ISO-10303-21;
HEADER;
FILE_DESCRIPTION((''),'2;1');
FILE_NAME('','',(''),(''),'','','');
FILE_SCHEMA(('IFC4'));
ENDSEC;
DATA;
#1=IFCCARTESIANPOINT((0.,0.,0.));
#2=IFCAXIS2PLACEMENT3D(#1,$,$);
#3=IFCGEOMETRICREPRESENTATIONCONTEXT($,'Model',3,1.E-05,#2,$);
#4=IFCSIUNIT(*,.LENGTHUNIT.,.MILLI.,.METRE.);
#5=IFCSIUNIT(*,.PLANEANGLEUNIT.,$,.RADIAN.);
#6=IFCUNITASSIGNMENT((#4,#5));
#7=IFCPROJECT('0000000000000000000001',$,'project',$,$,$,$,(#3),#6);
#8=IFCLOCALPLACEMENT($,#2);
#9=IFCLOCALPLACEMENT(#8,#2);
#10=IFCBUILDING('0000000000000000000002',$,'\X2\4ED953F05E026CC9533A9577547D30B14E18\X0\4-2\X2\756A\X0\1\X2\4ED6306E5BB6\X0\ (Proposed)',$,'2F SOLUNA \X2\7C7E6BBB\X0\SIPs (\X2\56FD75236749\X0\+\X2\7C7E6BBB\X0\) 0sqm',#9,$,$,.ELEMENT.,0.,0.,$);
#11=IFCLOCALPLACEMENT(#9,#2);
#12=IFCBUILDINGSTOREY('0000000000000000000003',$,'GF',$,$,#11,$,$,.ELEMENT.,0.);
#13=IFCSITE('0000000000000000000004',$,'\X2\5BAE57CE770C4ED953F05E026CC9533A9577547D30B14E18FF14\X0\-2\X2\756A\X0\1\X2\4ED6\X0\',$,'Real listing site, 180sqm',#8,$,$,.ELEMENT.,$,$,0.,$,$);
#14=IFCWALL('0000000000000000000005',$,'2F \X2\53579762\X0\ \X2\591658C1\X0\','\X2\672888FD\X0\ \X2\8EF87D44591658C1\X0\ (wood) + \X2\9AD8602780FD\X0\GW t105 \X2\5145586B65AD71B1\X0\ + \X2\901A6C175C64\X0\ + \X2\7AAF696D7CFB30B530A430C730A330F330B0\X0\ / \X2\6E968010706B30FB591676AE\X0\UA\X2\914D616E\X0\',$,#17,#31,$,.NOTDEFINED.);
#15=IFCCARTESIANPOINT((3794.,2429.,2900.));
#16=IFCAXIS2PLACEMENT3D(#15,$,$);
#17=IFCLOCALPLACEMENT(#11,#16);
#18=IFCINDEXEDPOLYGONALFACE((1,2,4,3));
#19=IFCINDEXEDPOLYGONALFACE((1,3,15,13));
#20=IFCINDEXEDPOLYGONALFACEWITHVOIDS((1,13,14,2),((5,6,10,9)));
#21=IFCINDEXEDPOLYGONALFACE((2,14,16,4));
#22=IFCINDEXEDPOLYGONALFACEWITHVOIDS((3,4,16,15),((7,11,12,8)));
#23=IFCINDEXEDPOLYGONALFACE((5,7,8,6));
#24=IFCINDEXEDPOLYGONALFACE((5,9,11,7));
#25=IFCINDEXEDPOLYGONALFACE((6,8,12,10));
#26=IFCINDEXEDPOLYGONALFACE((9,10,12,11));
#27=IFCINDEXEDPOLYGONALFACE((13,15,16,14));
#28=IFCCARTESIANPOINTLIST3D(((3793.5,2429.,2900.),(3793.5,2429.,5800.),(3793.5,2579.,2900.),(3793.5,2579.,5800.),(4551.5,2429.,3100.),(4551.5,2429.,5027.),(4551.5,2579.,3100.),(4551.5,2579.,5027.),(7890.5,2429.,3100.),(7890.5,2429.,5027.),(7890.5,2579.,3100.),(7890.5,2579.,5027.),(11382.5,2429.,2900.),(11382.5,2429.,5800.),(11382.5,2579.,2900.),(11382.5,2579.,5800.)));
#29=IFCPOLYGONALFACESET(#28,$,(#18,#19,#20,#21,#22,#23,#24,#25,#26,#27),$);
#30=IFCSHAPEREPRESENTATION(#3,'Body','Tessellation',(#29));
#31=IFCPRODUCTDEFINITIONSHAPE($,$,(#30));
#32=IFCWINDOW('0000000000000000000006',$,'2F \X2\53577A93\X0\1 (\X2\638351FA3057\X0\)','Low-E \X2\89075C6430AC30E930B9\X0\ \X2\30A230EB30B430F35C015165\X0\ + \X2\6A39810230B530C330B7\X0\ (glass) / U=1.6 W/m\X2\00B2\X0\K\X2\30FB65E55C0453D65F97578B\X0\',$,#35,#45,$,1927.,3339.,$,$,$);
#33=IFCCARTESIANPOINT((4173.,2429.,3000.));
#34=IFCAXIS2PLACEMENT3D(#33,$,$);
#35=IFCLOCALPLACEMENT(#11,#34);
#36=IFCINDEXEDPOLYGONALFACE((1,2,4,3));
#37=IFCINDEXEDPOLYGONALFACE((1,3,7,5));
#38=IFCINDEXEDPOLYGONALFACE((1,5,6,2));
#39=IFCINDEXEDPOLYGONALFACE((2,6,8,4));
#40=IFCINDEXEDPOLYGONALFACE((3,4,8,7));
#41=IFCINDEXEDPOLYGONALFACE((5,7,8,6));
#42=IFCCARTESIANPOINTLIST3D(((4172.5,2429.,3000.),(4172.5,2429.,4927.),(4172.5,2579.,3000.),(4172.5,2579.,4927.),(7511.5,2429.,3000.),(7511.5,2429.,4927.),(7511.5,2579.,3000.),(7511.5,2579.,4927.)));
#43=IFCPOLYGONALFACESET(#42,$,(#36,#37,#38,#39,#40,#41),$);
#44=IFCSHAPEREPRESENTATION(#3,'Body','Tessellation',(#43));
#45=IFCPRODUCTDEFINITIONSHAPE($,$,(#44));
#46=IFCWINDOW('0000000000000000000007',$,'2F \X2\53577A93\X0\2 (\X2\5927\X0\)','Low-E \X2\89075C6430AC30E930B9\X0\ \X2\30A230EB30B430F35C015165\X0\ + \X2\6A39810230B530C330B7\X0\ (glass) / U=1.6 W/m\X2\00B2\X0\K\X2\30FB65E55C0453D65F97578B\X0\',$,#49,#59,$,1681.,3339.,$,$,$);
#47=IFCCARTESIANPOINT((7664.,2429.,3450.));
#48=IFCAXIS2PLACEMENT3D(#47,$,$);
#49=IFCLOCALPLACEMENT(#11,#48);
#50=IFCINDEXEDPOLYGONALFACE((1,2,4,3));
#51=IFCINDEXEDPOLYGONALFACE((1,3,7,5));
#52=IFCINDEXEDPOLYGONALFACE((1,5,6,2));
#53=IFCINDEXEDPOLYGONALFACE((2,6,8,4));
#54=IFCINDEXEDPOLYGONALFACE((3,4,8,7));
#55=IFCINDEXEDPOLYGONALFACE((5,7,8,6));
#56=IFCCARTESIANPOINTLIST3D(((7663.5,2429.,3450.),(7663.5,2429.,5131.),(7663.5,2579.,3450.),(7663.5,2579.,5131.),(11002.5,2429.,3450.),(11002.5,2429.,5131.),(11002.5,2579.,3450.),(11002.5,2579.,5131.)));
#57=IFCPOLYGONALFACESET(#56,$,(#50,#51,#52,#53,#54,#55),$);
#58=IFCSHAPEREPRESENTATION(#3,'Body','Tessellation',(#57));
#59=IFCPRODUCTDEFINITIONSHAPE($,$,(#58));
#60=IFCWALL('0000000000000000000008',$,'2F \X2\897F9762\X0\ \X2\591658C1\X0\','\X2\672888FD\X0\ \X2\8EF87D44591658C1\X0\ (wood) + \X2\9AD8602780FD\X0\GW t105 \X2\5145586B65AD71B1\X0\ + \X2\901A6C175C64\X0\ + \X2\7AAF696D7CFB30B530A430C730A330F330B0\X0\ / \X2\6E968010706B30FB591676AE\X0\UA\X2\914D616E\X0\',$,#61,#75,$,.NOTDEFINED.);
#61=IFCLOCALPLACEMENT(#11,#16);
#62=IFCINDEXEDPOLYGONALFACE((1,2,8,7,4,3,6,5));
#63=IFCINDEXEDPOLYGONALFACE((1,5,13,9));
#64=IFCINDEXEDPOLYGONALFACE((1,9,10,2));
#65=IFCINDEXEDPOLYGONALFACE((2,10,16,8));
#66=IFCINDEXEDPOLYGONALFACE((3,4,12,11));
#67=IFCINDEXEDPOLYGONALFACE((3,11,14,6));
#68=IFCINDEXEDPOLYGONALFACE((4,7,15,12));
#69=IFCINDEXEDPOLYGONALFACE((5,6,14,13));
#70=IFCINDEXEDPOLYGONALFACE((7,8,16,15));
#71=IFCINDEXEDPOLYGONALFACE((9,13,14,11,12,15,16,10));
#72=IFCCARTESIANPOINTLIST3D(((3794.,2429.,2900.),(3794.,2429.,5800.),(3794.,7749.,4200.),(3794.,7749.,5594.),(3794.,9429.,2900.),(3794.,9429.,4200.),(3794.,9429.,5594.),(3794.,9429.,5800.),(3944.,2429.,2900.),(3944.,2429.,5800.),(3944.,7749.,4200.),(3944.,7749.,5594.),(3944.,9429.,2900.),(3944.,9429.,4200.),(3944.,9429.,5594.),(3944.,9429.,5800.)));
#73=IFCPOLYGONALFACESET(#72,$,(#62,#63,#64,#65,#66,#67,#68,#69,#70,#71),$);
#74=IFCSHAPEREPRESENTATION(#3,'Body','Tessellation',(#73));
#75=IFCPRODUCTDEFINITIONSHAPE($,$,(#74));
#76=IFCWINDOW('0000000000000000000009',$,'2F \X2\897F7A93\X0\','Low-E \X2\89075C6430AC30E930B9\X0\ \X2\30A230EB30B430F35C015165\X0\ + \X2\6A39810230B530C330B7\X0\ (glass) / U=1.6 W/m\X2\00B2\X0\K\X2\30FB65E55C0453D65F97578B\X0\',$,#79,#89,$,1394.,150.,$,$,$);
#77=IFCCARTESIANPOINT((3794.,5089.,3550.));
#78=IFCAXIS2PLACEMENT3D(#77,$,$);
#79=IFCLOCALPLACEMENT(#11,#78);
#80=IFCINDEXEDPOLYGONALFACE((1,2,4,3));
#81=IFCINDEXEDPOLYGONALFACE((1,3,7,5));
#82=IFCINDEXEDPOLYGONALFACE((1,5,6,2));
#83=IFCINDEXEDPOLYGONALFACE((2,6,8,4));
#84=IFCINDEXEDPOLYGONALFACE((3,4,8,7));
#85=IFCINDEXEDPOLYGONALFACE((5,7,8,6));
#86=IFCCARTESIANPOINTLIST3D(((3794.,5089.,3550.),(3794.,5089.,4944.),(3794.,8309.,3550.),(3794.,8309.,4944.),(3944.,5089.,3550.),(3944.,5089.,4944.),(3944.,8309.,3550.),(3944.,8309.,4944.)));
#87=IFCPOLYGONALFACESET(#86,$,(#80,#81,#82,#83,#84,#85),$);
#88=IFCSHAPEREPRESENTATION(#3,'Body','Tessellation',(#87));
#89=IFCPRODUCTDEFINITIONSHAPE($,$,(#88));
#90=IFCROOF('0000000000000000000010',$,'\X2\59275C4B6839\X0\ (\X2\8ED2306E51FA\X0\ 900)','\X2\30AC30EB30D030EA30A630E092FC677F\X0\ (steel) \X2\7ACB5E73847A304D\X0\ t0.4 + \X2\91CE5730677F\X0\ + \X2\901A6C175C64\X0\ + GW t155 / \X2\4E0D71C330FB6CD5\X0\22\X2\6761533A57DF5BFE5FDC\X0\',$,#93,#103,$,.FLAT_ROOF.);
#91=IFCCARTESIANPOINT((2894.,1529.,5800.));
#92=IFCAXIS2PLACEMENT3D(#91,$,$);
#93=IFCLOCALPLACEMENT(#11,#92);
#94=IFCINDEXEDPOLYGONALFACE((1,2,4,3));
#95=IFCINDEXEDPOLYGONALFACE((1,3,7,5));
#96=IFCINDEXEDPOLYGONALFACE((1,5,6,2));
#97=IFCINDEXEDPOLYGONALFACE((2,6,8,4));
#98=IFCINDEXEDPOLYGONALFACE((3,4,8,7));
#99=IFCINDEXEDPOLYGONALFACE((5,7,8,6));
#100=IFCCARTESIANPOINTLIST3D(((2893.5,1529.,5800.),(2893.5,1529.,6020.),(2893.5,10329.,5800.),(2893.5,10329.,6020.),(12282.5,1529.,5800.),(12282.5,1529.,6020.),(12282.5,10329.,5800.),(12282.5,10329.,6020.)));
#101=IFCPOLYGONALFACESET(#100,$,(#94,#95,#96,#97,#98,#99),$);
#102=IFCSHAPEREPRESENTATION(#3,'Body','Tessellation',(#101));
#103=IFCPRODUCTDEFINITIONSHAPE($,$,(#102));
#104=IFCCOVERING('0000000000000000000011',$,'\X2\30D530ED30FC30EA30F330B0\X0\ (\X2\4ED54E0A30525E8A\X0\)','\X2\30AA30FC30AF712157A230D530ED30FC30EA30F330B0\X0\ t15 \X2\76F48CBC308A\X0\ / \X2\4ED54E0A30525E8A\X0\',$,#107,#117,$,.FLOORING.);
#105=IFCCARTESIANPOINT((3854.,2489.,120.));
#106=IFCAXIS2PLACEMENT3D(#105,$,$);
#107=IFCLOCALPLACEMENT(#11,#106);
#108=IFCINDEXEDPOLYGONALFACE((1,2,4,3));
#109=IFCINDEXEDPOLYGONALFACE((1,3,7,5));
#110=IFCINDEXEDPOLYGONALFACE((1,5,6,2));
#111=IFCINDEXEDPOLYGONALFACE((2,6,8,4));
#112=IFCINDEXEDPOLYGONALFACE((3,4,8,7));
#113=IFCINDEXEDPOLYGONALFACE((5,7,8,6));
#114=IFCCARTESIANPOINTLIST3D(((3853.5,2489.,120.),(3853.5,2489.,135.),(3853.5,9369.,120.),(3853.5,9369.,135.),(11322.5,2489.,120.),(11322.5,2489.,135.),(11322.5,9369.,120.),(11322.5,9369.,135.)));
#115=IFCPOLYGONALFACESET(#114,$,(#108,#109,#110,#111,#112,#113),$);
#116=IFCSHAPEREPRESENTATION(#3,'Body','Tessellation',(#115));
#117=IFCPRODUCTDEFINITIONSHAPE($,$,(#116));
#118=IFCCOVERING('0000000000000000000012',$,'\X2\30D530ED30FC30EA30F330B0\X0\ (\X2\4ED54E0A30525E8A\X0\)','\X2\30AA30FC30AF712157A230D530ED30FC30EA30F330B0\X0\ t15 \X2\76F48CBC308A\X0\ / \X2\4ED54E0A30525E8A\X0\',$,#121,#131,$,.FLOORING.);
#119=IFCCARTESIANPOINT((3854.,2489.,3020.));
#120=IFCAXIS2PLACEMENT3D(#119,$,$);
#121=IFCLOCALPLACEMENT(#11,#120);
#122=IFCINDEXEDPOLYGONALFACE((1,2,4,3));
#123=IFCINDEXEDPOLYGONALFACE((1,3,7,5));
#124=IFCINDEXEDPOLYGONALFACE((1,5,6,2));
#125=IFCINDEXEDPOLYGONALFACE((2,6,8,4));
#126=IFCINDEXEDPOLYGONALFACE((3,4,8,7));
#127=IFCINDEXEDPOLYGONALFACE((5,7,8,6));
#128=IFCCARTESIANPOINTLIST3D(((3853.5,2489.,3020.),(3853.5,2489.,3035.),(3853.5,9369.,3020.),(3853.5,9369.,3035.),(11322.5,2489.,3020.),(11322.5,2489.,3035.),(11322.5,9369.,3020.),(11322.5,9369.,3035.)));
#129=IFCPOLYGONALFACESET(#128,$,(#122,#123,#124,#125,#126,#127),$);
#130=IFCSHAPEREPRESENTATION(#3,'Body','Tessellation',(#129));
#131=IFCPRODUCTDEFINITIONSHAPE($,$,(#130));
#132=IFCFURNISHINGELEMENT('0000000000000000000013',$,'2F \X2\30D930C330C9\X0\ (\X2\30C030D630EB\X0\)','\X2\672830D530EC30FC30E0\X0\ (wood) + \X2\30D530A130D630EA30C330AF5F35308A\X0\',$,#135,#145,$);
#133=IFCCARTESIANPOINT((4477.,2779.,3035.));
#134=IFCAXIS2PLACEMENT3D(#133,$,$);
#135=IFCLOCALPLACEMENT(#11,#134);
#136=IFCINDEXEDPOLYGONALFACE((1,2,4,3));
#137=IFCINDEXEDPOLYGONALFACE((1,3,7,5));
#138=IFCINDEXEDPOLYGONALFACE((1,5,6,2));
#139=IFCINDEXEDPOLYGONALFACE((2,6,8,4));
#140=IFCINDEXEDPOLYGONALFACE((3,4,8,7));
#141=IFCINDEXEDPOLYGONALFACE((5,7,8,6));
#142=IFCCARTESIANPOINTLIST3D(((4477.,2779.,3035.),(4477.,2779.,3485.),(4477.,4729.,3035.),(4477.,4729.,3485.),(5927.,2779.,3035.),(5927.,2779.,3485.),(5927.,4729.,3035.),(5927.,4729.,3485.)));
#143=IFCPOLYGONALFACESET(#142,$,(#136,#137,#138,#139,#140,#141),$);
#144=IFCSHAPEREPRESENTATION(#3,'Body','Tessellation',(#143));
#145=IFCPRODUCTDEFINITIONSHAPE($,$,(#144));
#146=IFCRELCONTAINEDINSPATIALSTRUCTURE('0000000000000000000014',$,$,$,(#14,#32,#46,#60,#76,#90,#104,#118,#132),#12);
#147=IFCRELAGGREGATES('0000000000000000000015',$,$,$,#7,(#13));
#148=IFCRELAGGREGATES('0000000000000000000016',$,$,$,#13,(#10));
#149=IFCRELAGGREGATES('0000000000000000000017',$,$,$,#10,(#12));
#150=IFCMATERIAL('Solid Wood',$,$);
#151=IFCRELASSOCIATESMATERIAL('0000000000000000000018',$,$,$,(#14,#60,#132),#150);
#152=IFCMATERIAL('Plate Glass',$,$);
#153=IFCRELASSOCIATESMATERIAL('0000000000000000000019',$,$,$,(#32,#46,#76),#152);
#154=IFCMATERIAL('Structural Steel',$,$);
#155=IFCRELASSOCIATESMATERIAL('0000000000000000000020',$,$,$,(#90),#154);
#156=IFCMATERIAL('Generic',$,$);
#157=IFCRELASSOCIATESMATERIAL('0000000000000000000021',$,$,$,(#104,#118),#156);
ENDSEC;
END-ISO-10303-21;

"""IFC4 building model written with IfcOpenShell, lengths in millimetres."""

from ifc_helpers import new_model, si_unit, frame, frame_2d, origin, place, context, project, spatial, rectangle, extrude, material, element, fill, save


model = new_model("IFC4")

# Units and contexts
model_context = context("Model", 3, precision=1e-05, world=origin())
ifc_project = project(units=[si_unit("LENGTHUNIT", "METRE", prefix="MILLI"), si_unit("PLANEANGLEUNIT", "RADIAN")], contexts=[model_context])

# Site, building, storey
site_placement = place(None, origin())
site = spatial("IfcSite", under=ifc_project, at=site_placement, Name="宮城県仙台市泉区長命ケ丘４-2番1他", ObjectType="Real listing site, 180sqm", CompositionType="ELEMENT", RefElevation=0.0)
building_placement = place(site_placement, origin())
building = spatial("IfcBuilding", under=site, at=building_placement, Name="仙台市泉区長命ケ丘4-2番1他の家 (Proposed)", ObjectType="2F SOLUNA 籾殻SIPs (国産杉+籾殻) 0sqm", CompositionType="ELEMENT", ElevationOfRefHeight=0.0, ElevationOfTerrain=0.0)
storey_placement = place(building_placement, origin())
storey = spatial("IfcBuildingStorey", under=building, at=storey_placement, Name="GF", CompositionType="ELEMENT", Elevation=0.0)

# Shared definitions
ifc_material_1 = material(Name="Solid Wood")

# Shared definitions
ifc_material_2 = material(Name="Plate Glass")

# Wall, openings, windows
wall_1_placement = place(storey_placement, frame((3794.0, 2429.0, 2900.0)))
wall_1 = element("IfcWall", 1, at=wall_1_placement, inside=storey, material=ifc_material_1, Name="2F 南面 外壁", Description="木製 軸組外壁 (wood) + 高性能GW t105 充填断熱 + 通気層 + 窯業系サイディング / 準耐火・外皮UA配慮", PredefinedType="NOTDEFINED", context=model_context, shape_type="SweptSolid", body=[
    extrude(rectangle(XDim=7589.0, YDim=150.0, at=frame_2d((3794.0, 75.0))), frame((3794.0, 2429.0, 2900.0)), (0.0, 0.0, 1.0), 2900.0),
])
opening_1_placement = place(storey_placement, frame((4173.0, 2429.0, 3000.0)))
opening_1 = element("IfcOpeningElement", 2, at=opening_1_placement, cuts=wall_1, PredefinedType="NOTDEFINED", context=model_context, shape_type="SweptSolid", body=[
    extrude(rectangle(XDim=3339.0, YDim=150.0, at=frame_2d((1669.0, 75.0))), frame((4173.0, 2429.0, 3000.0)), (0.0, 0.0, 1.0), 1927.0),
])
opening_2_placement = place(storey_placement, frame((7664.0, 2429.0, 3450.0)))
opening_2 = element("IfcOpeningElement", 3, at=opening_2_placement, cuts=wall_1, PredefinedType="NOTDEFINED", context=model_context, shape_type="SweptSolid", body=[
    extrude(rectangle(XDim=3339.0, YDim=150.0, at=frame_2d((1669.0, 75.0))), frame((7664.0, 2429.0, 3450.0)), (0.0, 0.0, 1.0), 1681.0),
])
window_1_placement = place(storey_placement, frame((4173.0, 2429.0, 3000.0)))
window_1 = element("IfcWindow", 4, at=window_1_placement, inside=storey, material=ifc_material_2, Name="2F 南窓1 (掃出し)", Description="Low-E 複層ガラス アルゴン封入 + 樹脂サッシ (glass) / U=1.6 W/m²K・日射取得型", OverallHeight=1927.0, OverallWidth=3339.0, context=model_context, shape_type="SweptSolid", body=[
    extrude(rectangle(XDim=3339.0, YDim=150.0, at=frame_2d((1669.0, 75.0))), frame((4173.0, 2429.0, 3000.0)), (0.0, 0.0, 1.0), 1927.0),
])
fill(opening_1, window_1)
window_2_placement = place(storey_placement, frame((7664.0, 2429.0, 3450.0)))
window_2 = element("IfcWindow", 5, at=window_2_placement, inside=storey, material=ifc_material_2, Name="2F 南窓2 (大)", Description="Low-E 複層ガラス アルゴン封入 + 樹脂サッシ (glass) / U=1.6 W/m²K・日射取得型", OverallHeight=1681.0, OverallWidth=3339.0, context=model_context, shape_type="SweptSolid", body=[
    extrude(rectangle(XDim=3339.0, YDim=150.0, at=frame_2d((1669.0, 75.0))), frame((7664.0, 2429.0, 3450.0)), (0.0, 0.0, 1.0), 1681.0),
])
fill(opening_2, window_2)

# Wall, opening, window
wall_2_placement = place(storey_placement, frame((3794.0, 2429.0, 2900.0)))
wall_2 = element("IfcWall", 6, at=wall_2_placement, inside=storey, material=ifc_material_1, Name="2F 西面 外壁", Description="木製 軸組外壁 (wood) + 高性能GW t105 充填断熱 + 通気層 + 窯業系サイディング / 準耐火・外皮UA配慮", PredefinedType="NOTDEFINED", context=model_context, shape_type="SweptSolid", body=[
    extrude(rectangle(XDim=150.0, YDim=7000.0, at=frame_2d((75.0, 3500.0))), frame((3794.0, 2429.0, 2900.0)), (0.0, 0.0, 1.0), 2900.0),
])
opening_3_placement = place(storey_placement, frame((3794.0, 5089.0, 3550.0)))
opening_3 = element("IfcOpeningElement", 7, at=opening_3_placement, cuts=wall_2, PredefinedType="NOTDEFINED", context=model_context, shape_type="SweptSolid", body=[
    extrude(rectangle(XDim=150.0, YDim=3220.0, at=frame_2d((75.0, 1610.0))), frame((3794.0, 5089.0, 3550.0)), (0.0, 0.0, 1.0), 1394.0),
])
window_3_placement = place(storey_placement, frame((3794.0, 5089.0, 3550.0)))
window_3 = element("IfcWindow", 8, at=window_3_placement, inside=storey, material=ifc_material_2, Name="2F 西窓", Description="Low-E 複層ガラス アルゴン封入 + 樹脂サッシ (glass) / U=1.6 W/m²K・日射取得型", OverallHeight=1394.0, OverallWidth=150.0, context=model_context, shape_type="SweptSolid", body=[
    extrude(rectangle(XDim=150.0, YDim=3220.0, at=frame_2d((75.0, 1610.0))), frame((3794.0, 5089.0, 3550.0)), (0.0, 0.0, 1.0), 1394.0),
])
fill(opening_3, window_3)

# Roof
ifc_material_3 = material(Name="Structural Steel")
roof_placement = place(storey_placement, frame((2894.0, 1529.0, 5800.0)))
element("IfcRoof", 9, at=roof_placement, inside=storey, material=ifc_material_3, Name="大屋根 (軒の出 900)", Description="ガルバリウム鋼板 (steel) 立平葺き t0.4 + 野地板 + 通気層 + GW t155 / 不燃・法22条区域対応", PredefinedType="FLAT_ROOF", context=model_context, shape_type="SweptSolid", body=[
    extrude(rectangle(XDim=9389.0, YDim=8800.0, at=frame_2d((4694.0, 4400.0))), frame((2894.0, 1529.0, 5800.0)), (0.0, 0.0, 1.0), 220.0),
])

# Coverings
ifc_material_4 = material(Name="Generic")
covering_1_placement = place(storey_placement, frame((3854.0, 2489.0, 120.0)))
element("IfcCovering", 10, at=covering_1_placement, inside=storey, material=ifc_material_4, Name="フローリング (仕上げ床)", Description="オーク無垢フローリング t15 直貼り / 仕上げ床", PredefinedType="FLOORING", context=model_context, shape_type="SweptSolid", body=[
    extrude(rectangle(XDim=7469.0, YDim=6880.0, at=frame_2d((3734.0, 3440.0))), frame((3854.0, 2489.0, 120.0)), (0.0, 0.0, 1.0), 15.0),
])
covering_2_placement = place(storey_placement, frame((3854.0, 2489.0, 3020.0)))
element("IfcCovering", 11, at=covering_2_placement, inside=storey, material=ifc_material_4, Name="フローリング (仕上げ床)", Description="オーク無垢フローリング t15 直貼り / 仕上げ床", PredefinedType="FLOORING", context=model_context, shape_type="SweptSolid", body=[
    extrude(rectangle(XDim=7469.0, YDim=6880.0, at=frame_2d((3734.0, 3440.0))), frame((3854.0, 2489.0, 3020.0)), (0.0, 0.0, 1.0), 15.0),
])

# Furnishing element
furnishing_placement = place(storey_placement, frame((4477.0, 2779.0, 3035.0)))
element("IfcFurnishingElement", 12, at=furnishing_placement, inside=storey, material=ifc_material_1, Name="2F ベッド (ダブル)", Description="木フレーム (wood) + ファブリック張り", context=model_context, shape_type="SweptSolid", body=[
    extrude(rectangle(XDim=1450.0, YDim=1950.0, at=frame_2d((725.0, 975.0))), frame((4477.0, 2779.0, 3035.0)), (0.0, 0.0, 1.0), 450.0),
])

save(model, "model.ifc")
